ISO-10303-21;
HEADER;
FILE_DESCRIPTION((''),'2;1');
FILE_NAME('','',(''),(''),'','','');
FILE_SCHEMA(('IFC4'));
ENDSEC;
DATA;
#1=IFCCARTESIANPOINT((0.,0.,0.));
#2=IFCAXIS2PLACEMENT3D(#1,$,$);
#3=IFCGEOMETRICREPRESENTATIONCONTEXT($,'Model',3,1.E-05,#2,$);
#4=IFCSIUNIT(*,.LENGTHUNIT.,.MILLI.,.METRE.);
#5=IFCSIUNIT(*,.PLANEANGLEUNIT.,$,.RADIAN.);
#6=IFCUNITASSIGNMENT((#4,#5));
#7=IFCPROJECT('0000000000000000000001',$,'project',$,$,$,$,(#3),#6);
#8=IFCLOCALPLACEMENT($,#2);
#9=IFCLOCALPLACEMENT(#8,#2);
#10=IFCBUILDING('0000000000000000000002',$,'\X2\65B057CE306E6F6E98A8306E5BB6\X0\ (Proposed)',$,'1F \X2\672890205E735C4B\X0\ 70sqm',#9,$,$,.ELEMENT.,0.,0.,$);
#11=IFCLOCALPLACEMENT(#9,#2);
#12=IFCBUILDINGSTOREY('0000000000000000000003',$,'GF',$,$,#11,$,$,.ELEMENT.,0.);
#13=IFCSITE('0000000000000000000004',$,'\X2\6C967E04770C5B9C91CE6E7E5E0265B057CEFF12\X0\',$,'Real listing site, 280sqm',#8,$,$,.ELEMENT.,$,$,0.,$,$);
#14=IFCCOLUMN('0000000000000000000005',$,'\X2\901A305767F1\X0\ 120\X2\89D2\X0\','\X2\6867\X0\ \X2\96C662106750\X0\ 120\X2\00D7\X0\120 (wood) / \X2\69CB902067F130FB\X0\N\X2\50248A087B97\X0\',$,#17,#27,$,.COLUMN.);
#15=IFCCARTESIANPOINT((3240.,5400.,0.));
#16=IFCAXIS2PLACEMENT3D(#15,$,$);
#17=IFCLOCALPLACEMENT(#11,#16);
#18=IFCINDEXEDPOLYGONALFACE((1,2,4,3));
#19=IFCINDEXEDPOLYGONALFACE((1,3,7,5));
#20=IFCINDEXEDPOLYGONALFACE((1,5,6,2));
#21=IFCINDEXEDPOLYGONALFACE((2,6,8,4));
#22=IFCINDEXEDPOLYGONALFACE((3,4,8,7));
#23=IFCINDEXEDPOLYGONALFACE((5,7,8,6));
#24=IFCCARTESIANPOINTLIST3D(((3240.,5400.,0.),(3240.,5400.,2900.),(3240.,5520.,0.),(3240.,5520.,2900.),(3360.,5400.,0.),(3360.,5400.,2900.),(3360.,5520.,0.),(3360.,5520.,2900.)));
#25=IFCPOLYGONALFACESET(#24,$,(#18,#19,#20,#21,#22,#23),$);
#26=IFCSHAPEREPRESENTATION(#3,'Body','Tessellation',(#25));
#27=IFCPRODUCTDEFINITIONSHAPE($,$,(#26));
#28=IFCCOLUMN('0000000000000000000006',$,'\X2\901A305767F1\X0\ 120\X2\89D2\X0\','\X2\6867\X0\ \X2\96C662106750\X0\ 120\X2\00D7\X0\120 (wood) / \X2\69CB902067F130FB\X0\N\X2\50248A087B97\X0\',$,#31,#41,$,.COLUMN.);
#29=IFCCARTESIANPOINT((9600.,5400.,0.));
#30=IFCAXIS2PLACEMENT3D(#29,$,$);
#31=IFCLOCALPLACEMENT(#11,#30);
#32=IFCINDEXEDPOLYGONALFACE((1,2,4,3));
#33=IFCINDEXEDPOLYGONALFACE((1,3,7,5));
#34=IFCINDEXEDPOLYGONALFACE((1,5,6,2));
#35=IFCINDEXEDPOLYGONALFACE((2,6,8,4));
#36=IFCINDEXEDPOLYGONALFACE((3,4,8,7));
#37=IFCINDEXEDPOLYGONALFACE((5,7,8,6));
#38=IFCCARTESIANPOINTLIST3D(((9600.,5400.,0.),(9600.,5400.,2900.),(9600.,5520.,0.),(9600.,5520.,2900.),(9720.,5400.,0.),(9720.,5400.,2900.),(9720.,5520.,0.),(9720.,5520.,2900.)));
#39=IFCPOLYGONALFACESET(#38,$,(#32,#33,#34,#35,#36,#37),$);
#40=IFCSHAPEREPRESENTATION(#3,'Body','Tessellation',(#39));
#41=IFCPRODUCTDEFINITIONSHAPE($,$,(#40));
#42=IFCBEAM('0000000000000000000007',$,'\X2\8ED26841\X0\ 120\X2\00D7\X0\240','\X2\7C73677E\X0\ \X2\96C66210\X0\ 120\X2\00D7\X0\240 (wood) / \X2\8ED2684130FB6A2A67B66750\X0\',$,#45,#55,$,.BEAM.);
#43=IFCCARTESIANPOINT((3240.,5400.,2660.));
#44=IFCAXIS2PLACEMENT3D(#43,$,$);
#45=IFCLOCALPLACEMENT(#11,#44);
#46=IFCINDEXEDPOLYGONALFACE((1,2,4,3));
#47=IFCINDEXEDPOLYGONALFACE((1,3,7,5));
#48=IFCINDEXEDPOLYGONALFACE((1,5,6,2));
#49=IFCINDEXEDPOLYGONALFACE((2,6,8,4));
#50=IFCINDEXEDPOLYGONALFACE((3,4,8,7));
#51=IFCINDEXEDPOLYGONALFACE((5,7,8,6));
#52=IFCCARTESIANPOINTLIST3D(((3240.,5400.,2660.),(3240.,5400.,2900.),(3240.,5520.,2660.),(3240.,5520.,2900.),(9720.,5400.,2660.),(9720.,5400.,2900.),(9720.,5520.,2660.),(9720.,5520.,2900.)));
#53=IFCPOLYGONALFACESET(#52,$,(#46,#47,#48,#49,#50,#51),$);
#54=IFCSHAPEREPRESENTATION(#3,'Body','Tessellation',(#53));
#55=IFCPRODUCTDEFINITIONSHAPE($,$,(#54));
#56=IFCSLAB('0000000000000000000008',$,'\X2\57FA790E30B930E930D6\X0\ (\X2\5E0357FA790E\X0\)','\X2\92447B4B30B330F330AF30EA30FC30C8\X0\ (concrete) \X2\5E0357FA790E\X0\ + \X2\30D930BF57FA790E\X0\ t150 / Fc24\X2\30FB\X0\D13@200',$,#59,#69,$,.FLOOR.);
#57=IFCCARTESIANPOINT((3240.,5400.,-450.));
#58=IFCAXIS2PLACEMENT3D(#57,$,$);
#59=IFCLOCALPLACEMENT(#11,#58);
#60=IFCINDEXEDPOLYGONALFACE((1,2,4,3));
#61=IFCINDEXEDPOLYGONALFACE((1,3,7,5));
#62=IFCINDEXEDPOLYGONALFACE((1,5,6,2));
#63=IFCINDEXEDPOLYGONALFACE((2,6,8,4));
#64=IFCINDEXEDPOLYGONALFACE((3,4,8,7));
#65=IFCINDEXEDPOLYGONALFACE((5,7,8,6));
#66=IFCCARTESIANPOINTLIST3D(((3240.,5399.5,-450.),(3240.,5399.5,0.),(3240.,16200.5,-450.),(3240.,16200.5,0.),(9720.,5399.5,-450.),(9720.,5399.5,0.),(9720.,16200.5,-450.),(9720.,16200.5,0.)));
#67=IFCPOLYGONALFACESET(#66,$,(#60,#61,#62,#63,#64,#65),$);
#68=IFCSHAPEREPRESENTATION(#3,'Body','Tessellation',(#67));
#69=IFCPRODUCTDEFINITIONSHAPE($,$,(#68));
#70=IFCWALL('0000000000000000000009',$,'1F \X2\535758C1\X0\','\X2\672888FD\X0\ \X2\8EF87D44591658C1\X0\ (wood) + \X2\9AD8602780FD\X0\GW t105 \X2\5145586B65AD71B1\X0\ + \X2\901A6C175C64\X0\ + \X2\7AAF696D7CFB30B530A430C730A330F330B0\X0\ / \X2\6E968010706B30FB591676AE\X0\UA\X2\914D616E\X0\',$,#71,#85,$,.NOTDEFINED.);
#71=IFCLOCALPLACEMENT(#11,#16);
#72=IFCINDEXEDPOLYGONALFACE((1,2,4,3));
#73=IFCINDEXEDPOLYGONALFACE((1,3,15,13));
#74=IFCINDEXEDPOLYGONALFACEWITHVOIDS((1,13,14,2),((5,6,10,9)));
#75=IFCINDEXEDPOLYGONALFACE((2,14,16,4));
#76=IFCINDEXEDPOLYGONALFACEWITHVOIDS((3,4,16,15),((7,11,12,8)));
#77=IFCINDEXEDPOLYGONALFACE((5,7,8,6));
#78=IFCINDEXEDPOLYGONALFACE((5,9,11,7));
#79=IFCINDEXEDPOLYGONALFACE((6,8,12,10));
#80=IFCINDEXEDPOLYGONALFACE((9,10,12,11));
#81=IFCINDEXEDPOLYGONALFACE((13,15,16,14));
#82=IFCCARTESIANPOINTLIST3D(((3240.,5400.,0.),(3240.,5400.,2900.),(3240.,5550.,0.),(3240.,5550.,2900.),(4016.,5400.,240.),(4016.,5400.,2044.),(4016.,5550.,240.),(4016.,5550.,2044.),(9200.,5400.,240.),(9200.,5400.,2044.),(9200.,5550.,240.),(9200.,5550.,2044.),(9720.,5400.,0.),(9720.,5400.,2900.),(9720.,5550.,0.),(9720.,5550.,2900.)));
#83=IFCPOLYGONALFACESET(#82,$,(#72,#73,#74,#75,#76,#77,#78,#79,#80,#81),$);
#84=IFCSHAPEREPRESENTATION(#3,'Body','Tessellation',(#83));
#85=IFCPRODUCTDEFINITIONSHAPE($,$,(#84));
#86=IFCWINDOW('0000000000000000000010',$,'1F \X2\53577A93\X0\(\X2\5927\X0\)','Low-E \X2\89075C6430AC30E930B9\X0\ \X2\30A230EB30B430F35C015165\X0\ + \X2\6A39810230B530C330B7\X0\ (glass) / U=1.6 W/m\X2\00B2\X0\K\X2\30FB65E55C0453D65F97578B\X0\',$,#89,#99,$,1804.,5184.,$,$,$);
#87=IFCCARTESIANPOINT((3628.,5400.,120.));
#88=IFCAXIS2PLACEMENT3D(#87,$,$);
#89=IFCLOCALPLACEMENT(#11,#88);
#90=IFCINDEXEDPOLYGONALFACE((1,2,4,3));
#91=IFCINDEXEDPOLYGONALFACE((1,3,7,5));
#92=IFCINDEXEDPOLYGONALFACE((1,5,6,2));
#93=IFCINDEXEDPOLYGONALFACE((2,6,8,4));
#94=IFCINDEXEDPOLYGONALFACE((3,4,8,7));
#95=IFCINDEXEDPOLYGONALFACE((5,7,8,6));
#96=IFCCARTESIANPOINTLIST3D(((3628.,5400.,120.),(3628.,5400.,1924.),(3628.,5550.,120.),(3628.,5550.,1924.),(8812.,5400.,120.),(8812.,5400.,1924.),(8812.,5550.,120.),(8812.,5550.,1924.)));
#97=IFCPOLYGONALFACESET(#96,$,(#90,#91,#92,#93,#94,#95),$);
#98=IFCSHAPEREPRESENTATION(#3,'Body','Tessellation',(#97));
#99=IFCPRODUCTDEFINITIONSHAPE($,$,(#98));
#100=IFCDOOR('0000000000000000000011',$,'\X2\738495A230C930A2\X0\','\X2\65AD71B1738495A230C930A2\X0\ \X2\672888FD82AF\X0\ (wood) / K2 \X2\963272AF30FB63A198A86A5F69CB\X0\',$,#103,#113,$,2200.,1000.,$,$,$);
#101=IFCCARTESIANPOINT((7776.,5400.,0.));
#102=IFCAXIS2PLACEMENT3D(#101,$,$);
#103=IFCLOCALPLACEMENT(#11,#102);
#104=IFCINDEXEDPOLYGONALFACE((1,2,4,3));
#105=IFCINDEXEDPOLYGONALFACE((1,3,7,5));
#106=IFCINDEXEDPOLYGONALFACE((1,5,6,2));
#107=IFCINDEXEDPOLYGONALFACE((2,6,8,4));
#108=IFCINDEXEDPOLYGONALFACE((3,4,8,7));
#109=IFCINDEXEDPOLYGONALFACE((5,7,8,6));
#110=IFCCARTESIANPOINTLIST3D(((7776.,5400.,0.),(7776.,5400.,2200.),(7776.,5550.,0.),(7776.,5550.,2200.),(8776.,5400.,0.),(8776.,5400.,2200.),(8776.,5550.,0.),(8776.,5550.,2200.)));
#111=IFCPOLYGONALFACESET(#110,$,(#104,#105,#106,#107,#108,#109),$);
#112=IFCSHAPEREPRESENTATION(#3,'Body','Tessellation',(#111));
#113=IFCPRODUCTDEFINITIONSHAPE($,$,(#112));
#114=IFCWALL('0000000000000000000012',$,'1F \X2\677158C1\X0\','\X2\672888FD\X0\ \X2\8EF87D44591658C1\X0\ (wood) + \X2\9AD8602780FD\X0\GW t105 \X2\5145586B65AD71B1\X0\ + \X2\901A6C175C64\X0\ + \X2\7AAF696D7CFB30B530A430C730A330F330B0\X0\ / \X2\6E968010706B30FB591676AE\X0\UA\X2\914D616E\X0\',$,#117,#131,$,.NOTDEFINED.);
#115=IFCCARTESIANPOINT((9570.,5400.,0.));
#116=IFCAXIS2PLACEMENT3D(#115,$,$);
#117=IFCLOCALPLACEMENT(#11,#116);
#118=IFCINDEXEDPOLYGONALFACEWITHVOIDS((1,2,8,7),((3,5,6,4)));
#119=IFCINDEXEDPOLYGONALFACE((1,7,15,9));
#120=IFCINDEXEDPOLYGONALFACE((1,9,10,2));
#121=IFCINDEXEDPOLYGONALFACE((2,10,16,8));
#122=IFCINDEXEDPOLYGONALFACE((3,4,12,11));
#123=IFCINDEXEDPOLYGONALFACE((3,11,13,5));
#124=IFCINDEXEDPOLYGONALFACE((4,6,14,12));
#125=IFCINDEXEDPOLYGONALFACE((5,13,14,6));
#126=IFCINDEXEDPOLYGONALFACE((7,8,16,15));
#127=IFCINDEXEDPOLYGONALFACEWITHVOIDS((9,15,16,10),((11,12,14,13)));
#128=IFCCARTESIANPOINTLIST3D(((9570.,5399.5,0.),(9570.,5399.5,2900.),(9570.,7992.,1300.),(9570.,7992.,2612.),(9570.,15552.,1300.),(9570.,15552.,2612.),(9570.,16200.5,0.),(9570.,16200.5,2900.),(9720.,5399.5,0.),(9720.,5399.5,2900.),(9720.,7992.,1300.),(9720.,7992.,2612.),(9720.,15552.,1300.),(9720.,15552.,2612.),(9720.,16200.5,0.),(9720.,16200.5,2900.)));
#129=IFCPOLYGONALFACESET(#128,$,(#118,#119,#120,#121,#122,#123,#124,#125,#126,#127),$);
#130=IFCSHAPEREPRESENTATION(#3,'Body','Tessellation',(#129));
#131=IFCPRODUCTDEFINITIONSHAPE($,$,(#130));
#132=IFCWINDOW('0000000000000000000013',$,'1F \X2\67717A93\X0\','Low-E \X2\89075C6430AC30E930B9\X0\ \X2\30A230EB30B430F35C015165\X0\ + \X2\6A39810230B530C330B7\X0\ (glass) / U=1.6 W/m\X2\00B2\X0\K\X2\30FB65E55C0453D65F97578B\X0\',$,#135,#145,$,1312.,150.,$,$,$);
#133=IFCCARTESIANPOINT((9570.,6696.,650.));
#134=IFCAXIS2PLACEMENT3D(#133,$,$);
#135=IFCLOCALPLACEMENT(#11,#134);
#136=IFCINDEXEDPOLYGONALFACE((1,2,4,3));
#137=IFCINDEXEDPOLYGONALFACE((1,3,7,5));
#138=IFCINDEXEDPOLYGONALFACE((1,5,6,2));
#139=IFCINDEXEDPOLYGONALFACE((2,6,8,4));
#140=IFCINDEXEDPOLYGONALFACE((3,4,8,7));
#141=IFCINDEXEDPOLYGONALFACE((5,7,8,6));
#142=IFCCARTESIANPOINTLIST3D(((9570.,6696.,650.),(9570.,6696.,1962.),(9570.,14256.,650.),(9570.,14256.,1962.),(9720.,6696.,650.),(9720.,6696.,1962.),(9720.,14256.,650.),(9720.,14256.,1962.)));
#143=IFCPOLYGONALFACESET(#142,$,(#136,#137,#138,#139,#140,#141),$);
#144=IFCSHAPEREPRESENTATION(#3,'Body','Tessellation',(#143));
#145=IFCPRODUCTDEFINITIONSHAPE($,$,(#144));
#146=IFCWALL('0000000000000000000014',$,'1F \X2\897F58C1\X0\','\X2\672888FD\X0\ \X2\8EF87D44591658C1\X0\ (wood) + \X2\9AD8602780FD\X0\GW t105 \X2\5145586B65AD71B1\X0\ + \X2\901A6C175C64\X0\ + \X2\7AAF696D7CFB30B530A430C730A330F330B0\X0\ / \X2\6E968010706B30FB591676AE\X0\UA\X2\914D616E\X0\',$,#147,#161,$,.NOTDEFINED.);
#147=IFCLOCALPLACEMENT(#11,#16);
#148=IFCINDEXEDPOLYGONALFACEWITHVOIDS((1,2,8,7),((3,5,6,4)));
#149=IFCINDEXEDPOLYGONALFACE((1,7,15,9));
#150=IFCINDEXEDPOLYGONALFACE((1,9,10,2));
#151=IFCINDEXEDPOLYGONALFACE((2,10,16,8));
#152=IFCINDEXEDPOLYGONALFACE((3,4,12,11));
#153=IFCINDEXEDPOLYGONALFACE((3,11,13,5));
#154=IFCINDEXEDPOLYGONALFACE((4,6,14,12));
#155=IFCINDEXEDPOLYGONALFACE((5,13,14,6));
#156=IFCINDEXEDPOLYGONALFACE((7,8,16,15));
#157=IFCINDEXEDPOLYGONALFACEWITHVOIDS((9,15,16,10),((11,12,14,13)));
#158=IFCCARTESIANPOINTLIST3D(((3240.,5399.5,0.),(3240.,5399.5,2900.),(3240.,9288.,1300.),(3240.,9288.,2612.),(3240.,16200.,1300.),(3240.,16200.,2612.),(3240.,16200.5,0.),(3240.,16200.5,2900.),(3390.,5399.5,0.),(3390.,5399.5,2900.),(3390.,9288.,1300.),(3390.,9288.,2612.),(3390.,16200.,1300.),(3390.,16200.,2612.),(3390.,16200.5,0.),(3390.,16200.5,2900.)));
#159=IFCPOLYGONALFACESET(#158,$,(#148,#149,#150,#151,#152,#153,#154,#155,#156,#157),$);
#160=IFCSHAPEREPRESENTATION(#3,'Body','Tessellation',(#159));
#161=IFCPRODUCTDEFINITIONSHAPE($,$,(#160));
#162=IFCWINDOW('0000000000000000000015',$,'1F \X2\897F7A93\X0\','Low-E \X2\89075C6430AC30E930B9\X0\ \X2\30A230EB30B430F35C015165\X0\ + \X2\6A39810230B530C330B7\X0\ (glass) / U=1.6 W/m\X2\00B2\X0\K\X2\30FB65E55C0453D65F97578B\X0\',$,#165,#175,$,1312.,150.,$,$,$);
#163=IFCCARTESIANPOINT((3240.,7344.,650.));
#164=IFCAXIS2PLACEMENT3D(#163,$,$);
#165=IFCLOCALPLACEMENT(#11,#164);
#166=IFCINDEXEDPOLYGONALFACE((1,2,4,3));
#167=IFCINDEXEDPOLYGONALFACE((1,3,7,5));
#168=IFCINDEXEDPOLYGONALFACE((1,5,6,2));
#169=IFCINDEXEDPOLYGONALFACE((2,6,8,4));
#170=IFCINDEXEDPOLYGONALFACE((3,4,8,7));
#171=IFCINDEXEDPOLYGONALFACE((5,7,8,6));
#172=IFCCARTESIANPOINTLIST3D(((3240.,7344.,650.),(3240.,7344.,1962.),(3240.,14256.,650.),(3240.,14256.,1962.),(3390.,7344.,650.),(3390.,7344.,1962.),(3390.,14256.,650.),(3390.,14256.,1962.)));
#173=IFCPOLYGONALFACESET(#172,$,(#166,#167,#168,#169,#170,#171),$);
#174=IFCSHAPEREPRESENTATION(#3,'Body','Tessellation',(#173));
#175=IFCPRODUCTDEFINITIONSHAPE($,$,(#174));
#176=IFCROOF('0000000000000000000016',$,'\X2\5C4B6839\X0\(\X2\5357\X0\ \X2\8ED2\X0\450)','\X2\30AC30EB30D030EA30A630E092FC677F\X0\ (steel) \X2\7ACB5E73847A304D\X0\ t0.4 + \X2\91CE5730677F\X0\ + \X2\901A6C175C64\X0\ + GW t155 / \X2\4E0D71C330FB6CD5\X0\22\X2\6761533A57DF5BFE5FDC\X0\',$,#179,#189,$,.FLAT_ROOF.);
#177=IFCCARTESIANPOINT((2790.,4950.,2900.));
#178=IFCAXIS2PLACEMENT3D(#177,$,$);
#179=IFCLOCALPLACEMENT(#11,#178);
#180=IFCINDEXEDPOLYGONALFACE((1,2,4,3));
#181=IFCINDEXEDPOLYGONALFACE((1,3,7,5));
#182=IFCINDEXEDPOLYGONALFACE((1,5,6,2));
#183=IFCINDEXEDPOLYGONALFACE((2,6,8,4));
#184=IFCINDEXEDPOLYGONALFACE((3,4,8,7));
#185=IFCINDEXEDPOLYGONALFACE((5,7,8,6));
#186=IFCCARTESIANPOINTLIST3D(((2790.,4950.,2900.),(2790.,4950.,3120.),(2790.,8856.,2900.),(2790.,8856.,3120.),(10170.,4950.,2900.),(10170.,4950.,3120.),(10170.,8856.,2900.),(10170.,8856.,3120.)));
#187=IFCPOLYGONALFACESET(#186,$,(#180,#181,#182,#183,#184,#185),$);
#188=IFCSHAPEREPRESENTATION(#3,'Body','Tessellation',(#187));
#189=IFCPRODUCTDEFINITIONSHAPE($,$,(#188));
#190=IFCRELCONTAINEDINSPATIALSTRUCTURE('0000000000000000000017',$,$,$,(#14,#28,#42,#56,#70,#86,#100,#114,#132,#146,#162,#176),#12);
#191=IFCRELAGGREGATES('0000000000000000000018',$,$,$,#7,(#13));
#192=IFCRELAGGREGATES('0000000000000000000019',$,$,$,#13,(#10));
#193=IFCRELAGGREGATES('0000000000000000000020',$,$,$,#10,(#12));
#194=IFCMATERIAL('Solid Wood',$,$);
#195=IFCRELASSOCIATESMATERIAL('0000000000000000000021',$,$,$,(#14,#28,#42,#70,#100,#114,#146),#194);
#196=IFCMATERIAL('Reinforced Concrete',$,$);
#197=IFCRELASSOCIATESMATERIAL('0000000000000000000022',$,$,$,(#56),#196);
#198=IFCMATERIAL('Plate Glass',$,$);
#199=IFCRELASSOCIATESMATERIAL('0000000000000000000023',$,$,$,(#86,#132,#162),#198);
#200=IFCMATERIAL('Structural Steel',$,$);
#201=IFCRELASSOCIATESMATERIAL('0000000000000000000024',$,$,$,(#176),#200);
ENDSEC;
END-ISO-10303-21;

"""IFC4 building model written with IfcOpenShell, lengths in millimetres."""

from ifc_helpers import new_model, si_unit, frame, frame_2d, origin, place, context, project, spatial, rectangle, extrude, material, element, fill, save


model = new_model("IFC4")

# Units and contexts
model_context = context("Model", 3, precision=1e-05, world=origin())
ifc_project = project(units=[si_unit("LENGTHUNIT", "METRE", prefix="MILLI"), si_unit("PLANEANGLEUNIT", "RADIAN")], contexts=[model_context])

# Site, building, storey
site_placement = place(None, origin())
site = spatial("IfcSite", under=ifc_project, at=site_placement, Name="沖縄県宜野湾市新城２", ObjectType="Real listing site, 280sqm", CompositionType="ELEMENT", RefElevation=0.0)
building_placement = place(site_placement, origin())
building = spatial("IfcBuilding", under=site, at=building_placement, Name="新城の潮風の家 (Proposed)", ObjectType="1F 木造平屋 70sqm", CompositionType="ELEMENT", ElevationOfRefHeight=0.0, ElevationOfTerrain=0.0)
storey_placement = place(building_placement, origin())
storey = spatial("IfcBuildingStorey", under=building, at=storey_placement, Name="GF", CompositionType="ELEMENT", Elevation=0.0)

# Columns
ifc_material_1 = material(Name="Solid Wood")
column_1_placement = place(storey_placement, frame((3240.0, 5400.0, 0.0)))
element("IfcColumn", 1, at=column_1_placement, inside=storey, material=ifc_material_1, Name="通し柱 120角", Description="桧 集成材 120×120 (wood) / 構造柱・N値計算", PredefinedType="COLUMN", context=model_context, shape_type="SweptSolid", body=[
    extrude(rectangle(XDim=120.0, YDim=120.0, at=frame_2d((60.0, 60.0))), frame((3240.0, 5400.0, 0.0)), (0.0, 0.0, 1.0), 2900.0),
])
column_2_placement = place(storey_placement, frame((9600.0, 5400.0, 0.0)))
element("IfcColumn", 2, at=column_2_placement, inside=storey, material=ifc_material_1, Name="通し柱 120角", Description="桧 集成材 120×120 (wood) / 構造柱・N値計算", PredefinedType="COLUMN", context=model_context, shape_type="SweptSolid", body=[
    extrude(rectangle(XDim=120.0, YDim=120.0, at=frame_2d((60.0, 60.0))), frame((9600.0, 5400.0, 0.0)), (0.0, 0.0, 1.0), 2900.0),
])

# Beam
beam_1_placement = place(storey_placement, frame((3240.0, 5400.0, 2660.0)))
element("IfcBeam", 3, at=beam_1_placement, inside=storey, material=ifc_material_1, Name="軒桁 120×240", Description="米松 集成 120×240 (wood) / 軒桁・横架材", PredefinedType="BEAM", context=model_context, shape_type="SweptSolid", body=[
    extrude(rectangle(XDim=6480.0, YDim=120.0, at=frame_2d((3240.0, 60.0))), frame((3240.0, 5400.0, 2660.0)), (0.0, 0.0, 1.0), 240.0),
])

# Slab
ifc_material_2 = material(Name="Reinforced Concrete")
slab_1_placement = place(storey_placement, frame((3240.0, 5400.0, -450.0)))
element("IfcSlab", 4, at=slab_1_placement, inside=storey, material=ifc_material_2, Name="基礎スラブ (布基礎)", Description="鉄筋コンクリート (concrete) 布基礎 + ベタ基礎 t150 / Fc24・D13@200", PredefinedType="FLOOR", context=model_context, shape_type="SweptSolid", body=[
    extrude(rectangle(XDim=6480.0, YDim=10801.0, at=frame_2d((3240.0, 5400.0))), frame((3240.0, 5400.0, -450.0)), (0.0, 0.0, 1.0), 450.0),
])

# Wall, openings, window, door
wall_1_placement = place(storey_placement, frame((3240.0, 5400.0, 0.0)))
wall_1 = element("IfcWall", 5, at=wall_1_placement, inside=storey, material=ifc_material_1, Name="1F 南壁", Description="木製 軸組外壁 (wood) + 高性能GW t105 充填断熱 + 通気層 + 窯業系サイディング / 準耐火・外皮UA配慮", PredefinedType="NOTDEFINED", context=model_context, shape_type="SweptSolid", body=[
    extrude(rectangle(XDim=6480.0, YDim=150.0, at=frame_2d((3240.0, 75.0))), frame((3240.0, 5400.0, 0.0)), (0.0, 0.0, 1.0), 2900.0),
])
opening_1_placement = place(storey_placement, frame((3628.0, 5400.0, 120.0)))
opening_1 = element("IfcOpeningElement", 6, at=opening_1_placement, cuts=wall_1, PredefinedType="NOTDEFINED", context=model_context, shape_type="SweptSolid", body=[
    extrude(rectangle(XDim=5184.0, YDim=150.0, at=frame_2d((2592.0, 75.0))), frame((3628.0, 5400.0, 120.0)), (0.0, 0.0, 1.0), 1804.0),
])
opening_2_placement = place(storey_placement, frame((7776.0, 5400.0, 0.0)))
opening_2 = element("IfcOpeningElement", 7, at=opening_2_placement, cuts=wall_1, PredefinedType="NOTDEFINED", context=model_context, shape_type="SweptSolid", body=[
    extrude(rectangle(XDim=1000.0, YDim=150.0, at=frame_2d((500.0, 75.0))), frame((7776.0, 5400.0, 0.0)), (0.0, 0.0, 1.0), 2200.0),
])
ifc_material_3 = material(Name="Plate Glass")
window_1_placement = place(storey_placement, frame((3628.0, 5400.0, 120.0)))
window_1 = element("IfcWindow", 8, at=window_1_placement, inside=storey, material=ifc_material_3, Name="1F 南窓(大)", Description="Low-E 複層ガラス アルゴン封入 + 樹脂サッシ (glass) / U=1.6 W/m²K・日射取得型", OverallHeight=1804.0, OverallWidth=5184.0, context=model_context, shape_type="SweptSolid", body=[
    extrude(rectangle(XDim=5184.0, YDim=150.0, at=frame_2d((2592.0, 75.0))), frame((3628.0, 5400.0, 120.0)), (0.0, 0.0, 1.0), 1804.0),
])
fill(opening_1, window_1)
door_placement = place(storey_placement, frame((7776.0, 5400.0, 0.0)))
door = element("IfcDoor", 9, at=door_placement, inside=storey, material=ifc_material_1, Name="玄関ドア", Description="断熱玄関ドア 木製芯 (wood) / K2 防犯・採風機構", OverallHeight=2200.0, OverallWidth=1000.0, context=model_context, shape_type="SweptSolid", body=[
    extrude(rectangle(XDim=1000.0, YDim=150.0, at=frame_2d((500.0, 75.0))), frame((7776.0, 5400.0, 0.0)), (0.0, 0.0, 1.0), 2200.0),
])
fill(opening_2, door)

# Walls, openings, windows
wall_2_placement = place(storey_placement, frame((9570.0, 5400.0, 0.0)))
wall_2 = element("IfcWall", 10, at=wall_2_placement, inside=storey, material=ifc_material_1, Name="1F 東壁", Description="木製 軸組外壁 (wood) + 高性能GW t105 充填断熱 + 通気層 + 窯業系サイディング / 準耐火・外皮UA配慮", PredefinedType="NOTDEFINED", context=model_context, shape_type="SweptSolid", body=[
    extrude(rectangle(XDim=150.0, YDim=10801.0, at=frame_2d((75.0, 5400.0))), frame((9570.0, 5400.0, 0.0)), (0.0, 0.0, 1.0), 2900.0),
])
opening_3_placement = place(storey_placement, frame((9570.0, 6696.0, 650.0)))
opening_3 = element("IfcOpeningElement", 11, at=opening_3_placement, cuts=wall_2, PredefinedType="NOTDEFINED", context=model_context, shape_type="SweptSolid", body=[
    extrude(rectangle(XDim=150.0, YDim=7560.0, at=frame_2d((75.0, 3780.0))), frame((9570.0, 6696.0, 650.0)), (0.0, 0.0, 1.0), 1312.0),
])
window_2_placement = place(storey_placement, frame((9570.0, 6696.0, 650.0)))
window_2 = element("IfcWindow", 12, at=window_2_placement, inside=storey, material=ifc_material_3, Name="1F 東窓", Description="Low-E 複層ガラス アルゴン封入 + 樹脂サッシ (glass) / U=1.6 W/m²K・日射取得型", OverallHeight=1312.0, OverallWidth=150.0, context=model_context, shape_type="SweptSolid", body=[
    extrude(rectangle(XDim=150.0, YDim=7560.0, at=frame_2d((75.0, 3780.0))), frame((9570.0, 6696.0, 650.0)), (0.0, 0.0, 1.0), 1312.0),
])
fill(opening_3, window_2)
wall_3_placement = place(storey_placement, frame((3240.0, 5400.0, 0.0)))
wall_3 = element("IfcWall", 13, at=wall_3_placement, inside=storey, material=ifc_material_1, Name="1F 西壁", Description="木製 軸組外壁 (wood) + 高性能GW t105 充填断熱 + 通気層 + 窯業系サイディング / 準耐火・外皮UA配慮", PredefinedType="NOTDEFINED", context=model_context, shape_type="SweptSolid", body=[
    extrude(rectangle(XDim=150.0, YDim=10801.0, at=frame_2d((75.0, 5400.0))), frame((3240.0, 5400.0, 0.0)), (0.0, 0.0, 1.0), 2900.0),
])
opening_4_placement = place(storey_placement, frame((3240.0, 7344.0, 650.0)))
opening_4 = element("IfcOpeningElement", 14, at=opening_4_placement, cuts=wall_3, PredefinedType="NOTDEFINED", context=model_context, shape_type="SweptSolid", body=[
    extrude(rectangle(XDim=150.0, YDim=6912.0, at=frame_2d((75.0, 3456.0))), frame((3240.0, 7344.0, 650.0)), (0.0, 0.0, 1.0), 1312.0),
])
window_3_placement = place(storey_placement, frame((3240.0, 7344.0, 650.0)))
window_3 = element("IfcWindow", 15, at=window_3_placement, inside=storey, material=ifc_material_3, Name="1F 西窓", Description="Low-E 複層ガラス アルゴン封入 + 樹脂サッシ (glass) / U=1.6 W/m²K・日射取得型", OverallHeight=1312.0, OverallWidth=150.0, context=model_context, shape_type="SweptSolid", body=[
    extrude(rectangle(XDim=150.0, YDim=6912.0, at=frame_2d((75.0, 3456.0))), frame((3240.0, 7344.0, 650.0)), (0.0, 0.0, 1.0), 1312.0),
])
fill(opening_4, window_3)

# Roof
ifc_material_4 = material(Name="Structural Steel")
roof_placement = place(storey_placement, frame((2790.0, 4950.0, 2900.0)))
element("IfcRoof", 16, at=roof_placement, inside=storey, material=ifc_material_4, Name="屋根(南 軒450)", Description="ガルバリウム鋼板 (steel) 立平葺き t0.4 + 野地板 + 通気層 + GW t155 / 不燃・法22条区域対応", PredefinedType="FLAT_ROOF", context=model_context, shape_type="SweptSolid", body=[
    extrude(rectangle(XDim=7380.0, YDim=3906.0, at=frame_2d((3690.0, 1953.0))), frame((2790.0, 4950.0, 2900.0)), (0.0, 0.0, 1.0), 220.0),
])

save(model, "model.ifc")
